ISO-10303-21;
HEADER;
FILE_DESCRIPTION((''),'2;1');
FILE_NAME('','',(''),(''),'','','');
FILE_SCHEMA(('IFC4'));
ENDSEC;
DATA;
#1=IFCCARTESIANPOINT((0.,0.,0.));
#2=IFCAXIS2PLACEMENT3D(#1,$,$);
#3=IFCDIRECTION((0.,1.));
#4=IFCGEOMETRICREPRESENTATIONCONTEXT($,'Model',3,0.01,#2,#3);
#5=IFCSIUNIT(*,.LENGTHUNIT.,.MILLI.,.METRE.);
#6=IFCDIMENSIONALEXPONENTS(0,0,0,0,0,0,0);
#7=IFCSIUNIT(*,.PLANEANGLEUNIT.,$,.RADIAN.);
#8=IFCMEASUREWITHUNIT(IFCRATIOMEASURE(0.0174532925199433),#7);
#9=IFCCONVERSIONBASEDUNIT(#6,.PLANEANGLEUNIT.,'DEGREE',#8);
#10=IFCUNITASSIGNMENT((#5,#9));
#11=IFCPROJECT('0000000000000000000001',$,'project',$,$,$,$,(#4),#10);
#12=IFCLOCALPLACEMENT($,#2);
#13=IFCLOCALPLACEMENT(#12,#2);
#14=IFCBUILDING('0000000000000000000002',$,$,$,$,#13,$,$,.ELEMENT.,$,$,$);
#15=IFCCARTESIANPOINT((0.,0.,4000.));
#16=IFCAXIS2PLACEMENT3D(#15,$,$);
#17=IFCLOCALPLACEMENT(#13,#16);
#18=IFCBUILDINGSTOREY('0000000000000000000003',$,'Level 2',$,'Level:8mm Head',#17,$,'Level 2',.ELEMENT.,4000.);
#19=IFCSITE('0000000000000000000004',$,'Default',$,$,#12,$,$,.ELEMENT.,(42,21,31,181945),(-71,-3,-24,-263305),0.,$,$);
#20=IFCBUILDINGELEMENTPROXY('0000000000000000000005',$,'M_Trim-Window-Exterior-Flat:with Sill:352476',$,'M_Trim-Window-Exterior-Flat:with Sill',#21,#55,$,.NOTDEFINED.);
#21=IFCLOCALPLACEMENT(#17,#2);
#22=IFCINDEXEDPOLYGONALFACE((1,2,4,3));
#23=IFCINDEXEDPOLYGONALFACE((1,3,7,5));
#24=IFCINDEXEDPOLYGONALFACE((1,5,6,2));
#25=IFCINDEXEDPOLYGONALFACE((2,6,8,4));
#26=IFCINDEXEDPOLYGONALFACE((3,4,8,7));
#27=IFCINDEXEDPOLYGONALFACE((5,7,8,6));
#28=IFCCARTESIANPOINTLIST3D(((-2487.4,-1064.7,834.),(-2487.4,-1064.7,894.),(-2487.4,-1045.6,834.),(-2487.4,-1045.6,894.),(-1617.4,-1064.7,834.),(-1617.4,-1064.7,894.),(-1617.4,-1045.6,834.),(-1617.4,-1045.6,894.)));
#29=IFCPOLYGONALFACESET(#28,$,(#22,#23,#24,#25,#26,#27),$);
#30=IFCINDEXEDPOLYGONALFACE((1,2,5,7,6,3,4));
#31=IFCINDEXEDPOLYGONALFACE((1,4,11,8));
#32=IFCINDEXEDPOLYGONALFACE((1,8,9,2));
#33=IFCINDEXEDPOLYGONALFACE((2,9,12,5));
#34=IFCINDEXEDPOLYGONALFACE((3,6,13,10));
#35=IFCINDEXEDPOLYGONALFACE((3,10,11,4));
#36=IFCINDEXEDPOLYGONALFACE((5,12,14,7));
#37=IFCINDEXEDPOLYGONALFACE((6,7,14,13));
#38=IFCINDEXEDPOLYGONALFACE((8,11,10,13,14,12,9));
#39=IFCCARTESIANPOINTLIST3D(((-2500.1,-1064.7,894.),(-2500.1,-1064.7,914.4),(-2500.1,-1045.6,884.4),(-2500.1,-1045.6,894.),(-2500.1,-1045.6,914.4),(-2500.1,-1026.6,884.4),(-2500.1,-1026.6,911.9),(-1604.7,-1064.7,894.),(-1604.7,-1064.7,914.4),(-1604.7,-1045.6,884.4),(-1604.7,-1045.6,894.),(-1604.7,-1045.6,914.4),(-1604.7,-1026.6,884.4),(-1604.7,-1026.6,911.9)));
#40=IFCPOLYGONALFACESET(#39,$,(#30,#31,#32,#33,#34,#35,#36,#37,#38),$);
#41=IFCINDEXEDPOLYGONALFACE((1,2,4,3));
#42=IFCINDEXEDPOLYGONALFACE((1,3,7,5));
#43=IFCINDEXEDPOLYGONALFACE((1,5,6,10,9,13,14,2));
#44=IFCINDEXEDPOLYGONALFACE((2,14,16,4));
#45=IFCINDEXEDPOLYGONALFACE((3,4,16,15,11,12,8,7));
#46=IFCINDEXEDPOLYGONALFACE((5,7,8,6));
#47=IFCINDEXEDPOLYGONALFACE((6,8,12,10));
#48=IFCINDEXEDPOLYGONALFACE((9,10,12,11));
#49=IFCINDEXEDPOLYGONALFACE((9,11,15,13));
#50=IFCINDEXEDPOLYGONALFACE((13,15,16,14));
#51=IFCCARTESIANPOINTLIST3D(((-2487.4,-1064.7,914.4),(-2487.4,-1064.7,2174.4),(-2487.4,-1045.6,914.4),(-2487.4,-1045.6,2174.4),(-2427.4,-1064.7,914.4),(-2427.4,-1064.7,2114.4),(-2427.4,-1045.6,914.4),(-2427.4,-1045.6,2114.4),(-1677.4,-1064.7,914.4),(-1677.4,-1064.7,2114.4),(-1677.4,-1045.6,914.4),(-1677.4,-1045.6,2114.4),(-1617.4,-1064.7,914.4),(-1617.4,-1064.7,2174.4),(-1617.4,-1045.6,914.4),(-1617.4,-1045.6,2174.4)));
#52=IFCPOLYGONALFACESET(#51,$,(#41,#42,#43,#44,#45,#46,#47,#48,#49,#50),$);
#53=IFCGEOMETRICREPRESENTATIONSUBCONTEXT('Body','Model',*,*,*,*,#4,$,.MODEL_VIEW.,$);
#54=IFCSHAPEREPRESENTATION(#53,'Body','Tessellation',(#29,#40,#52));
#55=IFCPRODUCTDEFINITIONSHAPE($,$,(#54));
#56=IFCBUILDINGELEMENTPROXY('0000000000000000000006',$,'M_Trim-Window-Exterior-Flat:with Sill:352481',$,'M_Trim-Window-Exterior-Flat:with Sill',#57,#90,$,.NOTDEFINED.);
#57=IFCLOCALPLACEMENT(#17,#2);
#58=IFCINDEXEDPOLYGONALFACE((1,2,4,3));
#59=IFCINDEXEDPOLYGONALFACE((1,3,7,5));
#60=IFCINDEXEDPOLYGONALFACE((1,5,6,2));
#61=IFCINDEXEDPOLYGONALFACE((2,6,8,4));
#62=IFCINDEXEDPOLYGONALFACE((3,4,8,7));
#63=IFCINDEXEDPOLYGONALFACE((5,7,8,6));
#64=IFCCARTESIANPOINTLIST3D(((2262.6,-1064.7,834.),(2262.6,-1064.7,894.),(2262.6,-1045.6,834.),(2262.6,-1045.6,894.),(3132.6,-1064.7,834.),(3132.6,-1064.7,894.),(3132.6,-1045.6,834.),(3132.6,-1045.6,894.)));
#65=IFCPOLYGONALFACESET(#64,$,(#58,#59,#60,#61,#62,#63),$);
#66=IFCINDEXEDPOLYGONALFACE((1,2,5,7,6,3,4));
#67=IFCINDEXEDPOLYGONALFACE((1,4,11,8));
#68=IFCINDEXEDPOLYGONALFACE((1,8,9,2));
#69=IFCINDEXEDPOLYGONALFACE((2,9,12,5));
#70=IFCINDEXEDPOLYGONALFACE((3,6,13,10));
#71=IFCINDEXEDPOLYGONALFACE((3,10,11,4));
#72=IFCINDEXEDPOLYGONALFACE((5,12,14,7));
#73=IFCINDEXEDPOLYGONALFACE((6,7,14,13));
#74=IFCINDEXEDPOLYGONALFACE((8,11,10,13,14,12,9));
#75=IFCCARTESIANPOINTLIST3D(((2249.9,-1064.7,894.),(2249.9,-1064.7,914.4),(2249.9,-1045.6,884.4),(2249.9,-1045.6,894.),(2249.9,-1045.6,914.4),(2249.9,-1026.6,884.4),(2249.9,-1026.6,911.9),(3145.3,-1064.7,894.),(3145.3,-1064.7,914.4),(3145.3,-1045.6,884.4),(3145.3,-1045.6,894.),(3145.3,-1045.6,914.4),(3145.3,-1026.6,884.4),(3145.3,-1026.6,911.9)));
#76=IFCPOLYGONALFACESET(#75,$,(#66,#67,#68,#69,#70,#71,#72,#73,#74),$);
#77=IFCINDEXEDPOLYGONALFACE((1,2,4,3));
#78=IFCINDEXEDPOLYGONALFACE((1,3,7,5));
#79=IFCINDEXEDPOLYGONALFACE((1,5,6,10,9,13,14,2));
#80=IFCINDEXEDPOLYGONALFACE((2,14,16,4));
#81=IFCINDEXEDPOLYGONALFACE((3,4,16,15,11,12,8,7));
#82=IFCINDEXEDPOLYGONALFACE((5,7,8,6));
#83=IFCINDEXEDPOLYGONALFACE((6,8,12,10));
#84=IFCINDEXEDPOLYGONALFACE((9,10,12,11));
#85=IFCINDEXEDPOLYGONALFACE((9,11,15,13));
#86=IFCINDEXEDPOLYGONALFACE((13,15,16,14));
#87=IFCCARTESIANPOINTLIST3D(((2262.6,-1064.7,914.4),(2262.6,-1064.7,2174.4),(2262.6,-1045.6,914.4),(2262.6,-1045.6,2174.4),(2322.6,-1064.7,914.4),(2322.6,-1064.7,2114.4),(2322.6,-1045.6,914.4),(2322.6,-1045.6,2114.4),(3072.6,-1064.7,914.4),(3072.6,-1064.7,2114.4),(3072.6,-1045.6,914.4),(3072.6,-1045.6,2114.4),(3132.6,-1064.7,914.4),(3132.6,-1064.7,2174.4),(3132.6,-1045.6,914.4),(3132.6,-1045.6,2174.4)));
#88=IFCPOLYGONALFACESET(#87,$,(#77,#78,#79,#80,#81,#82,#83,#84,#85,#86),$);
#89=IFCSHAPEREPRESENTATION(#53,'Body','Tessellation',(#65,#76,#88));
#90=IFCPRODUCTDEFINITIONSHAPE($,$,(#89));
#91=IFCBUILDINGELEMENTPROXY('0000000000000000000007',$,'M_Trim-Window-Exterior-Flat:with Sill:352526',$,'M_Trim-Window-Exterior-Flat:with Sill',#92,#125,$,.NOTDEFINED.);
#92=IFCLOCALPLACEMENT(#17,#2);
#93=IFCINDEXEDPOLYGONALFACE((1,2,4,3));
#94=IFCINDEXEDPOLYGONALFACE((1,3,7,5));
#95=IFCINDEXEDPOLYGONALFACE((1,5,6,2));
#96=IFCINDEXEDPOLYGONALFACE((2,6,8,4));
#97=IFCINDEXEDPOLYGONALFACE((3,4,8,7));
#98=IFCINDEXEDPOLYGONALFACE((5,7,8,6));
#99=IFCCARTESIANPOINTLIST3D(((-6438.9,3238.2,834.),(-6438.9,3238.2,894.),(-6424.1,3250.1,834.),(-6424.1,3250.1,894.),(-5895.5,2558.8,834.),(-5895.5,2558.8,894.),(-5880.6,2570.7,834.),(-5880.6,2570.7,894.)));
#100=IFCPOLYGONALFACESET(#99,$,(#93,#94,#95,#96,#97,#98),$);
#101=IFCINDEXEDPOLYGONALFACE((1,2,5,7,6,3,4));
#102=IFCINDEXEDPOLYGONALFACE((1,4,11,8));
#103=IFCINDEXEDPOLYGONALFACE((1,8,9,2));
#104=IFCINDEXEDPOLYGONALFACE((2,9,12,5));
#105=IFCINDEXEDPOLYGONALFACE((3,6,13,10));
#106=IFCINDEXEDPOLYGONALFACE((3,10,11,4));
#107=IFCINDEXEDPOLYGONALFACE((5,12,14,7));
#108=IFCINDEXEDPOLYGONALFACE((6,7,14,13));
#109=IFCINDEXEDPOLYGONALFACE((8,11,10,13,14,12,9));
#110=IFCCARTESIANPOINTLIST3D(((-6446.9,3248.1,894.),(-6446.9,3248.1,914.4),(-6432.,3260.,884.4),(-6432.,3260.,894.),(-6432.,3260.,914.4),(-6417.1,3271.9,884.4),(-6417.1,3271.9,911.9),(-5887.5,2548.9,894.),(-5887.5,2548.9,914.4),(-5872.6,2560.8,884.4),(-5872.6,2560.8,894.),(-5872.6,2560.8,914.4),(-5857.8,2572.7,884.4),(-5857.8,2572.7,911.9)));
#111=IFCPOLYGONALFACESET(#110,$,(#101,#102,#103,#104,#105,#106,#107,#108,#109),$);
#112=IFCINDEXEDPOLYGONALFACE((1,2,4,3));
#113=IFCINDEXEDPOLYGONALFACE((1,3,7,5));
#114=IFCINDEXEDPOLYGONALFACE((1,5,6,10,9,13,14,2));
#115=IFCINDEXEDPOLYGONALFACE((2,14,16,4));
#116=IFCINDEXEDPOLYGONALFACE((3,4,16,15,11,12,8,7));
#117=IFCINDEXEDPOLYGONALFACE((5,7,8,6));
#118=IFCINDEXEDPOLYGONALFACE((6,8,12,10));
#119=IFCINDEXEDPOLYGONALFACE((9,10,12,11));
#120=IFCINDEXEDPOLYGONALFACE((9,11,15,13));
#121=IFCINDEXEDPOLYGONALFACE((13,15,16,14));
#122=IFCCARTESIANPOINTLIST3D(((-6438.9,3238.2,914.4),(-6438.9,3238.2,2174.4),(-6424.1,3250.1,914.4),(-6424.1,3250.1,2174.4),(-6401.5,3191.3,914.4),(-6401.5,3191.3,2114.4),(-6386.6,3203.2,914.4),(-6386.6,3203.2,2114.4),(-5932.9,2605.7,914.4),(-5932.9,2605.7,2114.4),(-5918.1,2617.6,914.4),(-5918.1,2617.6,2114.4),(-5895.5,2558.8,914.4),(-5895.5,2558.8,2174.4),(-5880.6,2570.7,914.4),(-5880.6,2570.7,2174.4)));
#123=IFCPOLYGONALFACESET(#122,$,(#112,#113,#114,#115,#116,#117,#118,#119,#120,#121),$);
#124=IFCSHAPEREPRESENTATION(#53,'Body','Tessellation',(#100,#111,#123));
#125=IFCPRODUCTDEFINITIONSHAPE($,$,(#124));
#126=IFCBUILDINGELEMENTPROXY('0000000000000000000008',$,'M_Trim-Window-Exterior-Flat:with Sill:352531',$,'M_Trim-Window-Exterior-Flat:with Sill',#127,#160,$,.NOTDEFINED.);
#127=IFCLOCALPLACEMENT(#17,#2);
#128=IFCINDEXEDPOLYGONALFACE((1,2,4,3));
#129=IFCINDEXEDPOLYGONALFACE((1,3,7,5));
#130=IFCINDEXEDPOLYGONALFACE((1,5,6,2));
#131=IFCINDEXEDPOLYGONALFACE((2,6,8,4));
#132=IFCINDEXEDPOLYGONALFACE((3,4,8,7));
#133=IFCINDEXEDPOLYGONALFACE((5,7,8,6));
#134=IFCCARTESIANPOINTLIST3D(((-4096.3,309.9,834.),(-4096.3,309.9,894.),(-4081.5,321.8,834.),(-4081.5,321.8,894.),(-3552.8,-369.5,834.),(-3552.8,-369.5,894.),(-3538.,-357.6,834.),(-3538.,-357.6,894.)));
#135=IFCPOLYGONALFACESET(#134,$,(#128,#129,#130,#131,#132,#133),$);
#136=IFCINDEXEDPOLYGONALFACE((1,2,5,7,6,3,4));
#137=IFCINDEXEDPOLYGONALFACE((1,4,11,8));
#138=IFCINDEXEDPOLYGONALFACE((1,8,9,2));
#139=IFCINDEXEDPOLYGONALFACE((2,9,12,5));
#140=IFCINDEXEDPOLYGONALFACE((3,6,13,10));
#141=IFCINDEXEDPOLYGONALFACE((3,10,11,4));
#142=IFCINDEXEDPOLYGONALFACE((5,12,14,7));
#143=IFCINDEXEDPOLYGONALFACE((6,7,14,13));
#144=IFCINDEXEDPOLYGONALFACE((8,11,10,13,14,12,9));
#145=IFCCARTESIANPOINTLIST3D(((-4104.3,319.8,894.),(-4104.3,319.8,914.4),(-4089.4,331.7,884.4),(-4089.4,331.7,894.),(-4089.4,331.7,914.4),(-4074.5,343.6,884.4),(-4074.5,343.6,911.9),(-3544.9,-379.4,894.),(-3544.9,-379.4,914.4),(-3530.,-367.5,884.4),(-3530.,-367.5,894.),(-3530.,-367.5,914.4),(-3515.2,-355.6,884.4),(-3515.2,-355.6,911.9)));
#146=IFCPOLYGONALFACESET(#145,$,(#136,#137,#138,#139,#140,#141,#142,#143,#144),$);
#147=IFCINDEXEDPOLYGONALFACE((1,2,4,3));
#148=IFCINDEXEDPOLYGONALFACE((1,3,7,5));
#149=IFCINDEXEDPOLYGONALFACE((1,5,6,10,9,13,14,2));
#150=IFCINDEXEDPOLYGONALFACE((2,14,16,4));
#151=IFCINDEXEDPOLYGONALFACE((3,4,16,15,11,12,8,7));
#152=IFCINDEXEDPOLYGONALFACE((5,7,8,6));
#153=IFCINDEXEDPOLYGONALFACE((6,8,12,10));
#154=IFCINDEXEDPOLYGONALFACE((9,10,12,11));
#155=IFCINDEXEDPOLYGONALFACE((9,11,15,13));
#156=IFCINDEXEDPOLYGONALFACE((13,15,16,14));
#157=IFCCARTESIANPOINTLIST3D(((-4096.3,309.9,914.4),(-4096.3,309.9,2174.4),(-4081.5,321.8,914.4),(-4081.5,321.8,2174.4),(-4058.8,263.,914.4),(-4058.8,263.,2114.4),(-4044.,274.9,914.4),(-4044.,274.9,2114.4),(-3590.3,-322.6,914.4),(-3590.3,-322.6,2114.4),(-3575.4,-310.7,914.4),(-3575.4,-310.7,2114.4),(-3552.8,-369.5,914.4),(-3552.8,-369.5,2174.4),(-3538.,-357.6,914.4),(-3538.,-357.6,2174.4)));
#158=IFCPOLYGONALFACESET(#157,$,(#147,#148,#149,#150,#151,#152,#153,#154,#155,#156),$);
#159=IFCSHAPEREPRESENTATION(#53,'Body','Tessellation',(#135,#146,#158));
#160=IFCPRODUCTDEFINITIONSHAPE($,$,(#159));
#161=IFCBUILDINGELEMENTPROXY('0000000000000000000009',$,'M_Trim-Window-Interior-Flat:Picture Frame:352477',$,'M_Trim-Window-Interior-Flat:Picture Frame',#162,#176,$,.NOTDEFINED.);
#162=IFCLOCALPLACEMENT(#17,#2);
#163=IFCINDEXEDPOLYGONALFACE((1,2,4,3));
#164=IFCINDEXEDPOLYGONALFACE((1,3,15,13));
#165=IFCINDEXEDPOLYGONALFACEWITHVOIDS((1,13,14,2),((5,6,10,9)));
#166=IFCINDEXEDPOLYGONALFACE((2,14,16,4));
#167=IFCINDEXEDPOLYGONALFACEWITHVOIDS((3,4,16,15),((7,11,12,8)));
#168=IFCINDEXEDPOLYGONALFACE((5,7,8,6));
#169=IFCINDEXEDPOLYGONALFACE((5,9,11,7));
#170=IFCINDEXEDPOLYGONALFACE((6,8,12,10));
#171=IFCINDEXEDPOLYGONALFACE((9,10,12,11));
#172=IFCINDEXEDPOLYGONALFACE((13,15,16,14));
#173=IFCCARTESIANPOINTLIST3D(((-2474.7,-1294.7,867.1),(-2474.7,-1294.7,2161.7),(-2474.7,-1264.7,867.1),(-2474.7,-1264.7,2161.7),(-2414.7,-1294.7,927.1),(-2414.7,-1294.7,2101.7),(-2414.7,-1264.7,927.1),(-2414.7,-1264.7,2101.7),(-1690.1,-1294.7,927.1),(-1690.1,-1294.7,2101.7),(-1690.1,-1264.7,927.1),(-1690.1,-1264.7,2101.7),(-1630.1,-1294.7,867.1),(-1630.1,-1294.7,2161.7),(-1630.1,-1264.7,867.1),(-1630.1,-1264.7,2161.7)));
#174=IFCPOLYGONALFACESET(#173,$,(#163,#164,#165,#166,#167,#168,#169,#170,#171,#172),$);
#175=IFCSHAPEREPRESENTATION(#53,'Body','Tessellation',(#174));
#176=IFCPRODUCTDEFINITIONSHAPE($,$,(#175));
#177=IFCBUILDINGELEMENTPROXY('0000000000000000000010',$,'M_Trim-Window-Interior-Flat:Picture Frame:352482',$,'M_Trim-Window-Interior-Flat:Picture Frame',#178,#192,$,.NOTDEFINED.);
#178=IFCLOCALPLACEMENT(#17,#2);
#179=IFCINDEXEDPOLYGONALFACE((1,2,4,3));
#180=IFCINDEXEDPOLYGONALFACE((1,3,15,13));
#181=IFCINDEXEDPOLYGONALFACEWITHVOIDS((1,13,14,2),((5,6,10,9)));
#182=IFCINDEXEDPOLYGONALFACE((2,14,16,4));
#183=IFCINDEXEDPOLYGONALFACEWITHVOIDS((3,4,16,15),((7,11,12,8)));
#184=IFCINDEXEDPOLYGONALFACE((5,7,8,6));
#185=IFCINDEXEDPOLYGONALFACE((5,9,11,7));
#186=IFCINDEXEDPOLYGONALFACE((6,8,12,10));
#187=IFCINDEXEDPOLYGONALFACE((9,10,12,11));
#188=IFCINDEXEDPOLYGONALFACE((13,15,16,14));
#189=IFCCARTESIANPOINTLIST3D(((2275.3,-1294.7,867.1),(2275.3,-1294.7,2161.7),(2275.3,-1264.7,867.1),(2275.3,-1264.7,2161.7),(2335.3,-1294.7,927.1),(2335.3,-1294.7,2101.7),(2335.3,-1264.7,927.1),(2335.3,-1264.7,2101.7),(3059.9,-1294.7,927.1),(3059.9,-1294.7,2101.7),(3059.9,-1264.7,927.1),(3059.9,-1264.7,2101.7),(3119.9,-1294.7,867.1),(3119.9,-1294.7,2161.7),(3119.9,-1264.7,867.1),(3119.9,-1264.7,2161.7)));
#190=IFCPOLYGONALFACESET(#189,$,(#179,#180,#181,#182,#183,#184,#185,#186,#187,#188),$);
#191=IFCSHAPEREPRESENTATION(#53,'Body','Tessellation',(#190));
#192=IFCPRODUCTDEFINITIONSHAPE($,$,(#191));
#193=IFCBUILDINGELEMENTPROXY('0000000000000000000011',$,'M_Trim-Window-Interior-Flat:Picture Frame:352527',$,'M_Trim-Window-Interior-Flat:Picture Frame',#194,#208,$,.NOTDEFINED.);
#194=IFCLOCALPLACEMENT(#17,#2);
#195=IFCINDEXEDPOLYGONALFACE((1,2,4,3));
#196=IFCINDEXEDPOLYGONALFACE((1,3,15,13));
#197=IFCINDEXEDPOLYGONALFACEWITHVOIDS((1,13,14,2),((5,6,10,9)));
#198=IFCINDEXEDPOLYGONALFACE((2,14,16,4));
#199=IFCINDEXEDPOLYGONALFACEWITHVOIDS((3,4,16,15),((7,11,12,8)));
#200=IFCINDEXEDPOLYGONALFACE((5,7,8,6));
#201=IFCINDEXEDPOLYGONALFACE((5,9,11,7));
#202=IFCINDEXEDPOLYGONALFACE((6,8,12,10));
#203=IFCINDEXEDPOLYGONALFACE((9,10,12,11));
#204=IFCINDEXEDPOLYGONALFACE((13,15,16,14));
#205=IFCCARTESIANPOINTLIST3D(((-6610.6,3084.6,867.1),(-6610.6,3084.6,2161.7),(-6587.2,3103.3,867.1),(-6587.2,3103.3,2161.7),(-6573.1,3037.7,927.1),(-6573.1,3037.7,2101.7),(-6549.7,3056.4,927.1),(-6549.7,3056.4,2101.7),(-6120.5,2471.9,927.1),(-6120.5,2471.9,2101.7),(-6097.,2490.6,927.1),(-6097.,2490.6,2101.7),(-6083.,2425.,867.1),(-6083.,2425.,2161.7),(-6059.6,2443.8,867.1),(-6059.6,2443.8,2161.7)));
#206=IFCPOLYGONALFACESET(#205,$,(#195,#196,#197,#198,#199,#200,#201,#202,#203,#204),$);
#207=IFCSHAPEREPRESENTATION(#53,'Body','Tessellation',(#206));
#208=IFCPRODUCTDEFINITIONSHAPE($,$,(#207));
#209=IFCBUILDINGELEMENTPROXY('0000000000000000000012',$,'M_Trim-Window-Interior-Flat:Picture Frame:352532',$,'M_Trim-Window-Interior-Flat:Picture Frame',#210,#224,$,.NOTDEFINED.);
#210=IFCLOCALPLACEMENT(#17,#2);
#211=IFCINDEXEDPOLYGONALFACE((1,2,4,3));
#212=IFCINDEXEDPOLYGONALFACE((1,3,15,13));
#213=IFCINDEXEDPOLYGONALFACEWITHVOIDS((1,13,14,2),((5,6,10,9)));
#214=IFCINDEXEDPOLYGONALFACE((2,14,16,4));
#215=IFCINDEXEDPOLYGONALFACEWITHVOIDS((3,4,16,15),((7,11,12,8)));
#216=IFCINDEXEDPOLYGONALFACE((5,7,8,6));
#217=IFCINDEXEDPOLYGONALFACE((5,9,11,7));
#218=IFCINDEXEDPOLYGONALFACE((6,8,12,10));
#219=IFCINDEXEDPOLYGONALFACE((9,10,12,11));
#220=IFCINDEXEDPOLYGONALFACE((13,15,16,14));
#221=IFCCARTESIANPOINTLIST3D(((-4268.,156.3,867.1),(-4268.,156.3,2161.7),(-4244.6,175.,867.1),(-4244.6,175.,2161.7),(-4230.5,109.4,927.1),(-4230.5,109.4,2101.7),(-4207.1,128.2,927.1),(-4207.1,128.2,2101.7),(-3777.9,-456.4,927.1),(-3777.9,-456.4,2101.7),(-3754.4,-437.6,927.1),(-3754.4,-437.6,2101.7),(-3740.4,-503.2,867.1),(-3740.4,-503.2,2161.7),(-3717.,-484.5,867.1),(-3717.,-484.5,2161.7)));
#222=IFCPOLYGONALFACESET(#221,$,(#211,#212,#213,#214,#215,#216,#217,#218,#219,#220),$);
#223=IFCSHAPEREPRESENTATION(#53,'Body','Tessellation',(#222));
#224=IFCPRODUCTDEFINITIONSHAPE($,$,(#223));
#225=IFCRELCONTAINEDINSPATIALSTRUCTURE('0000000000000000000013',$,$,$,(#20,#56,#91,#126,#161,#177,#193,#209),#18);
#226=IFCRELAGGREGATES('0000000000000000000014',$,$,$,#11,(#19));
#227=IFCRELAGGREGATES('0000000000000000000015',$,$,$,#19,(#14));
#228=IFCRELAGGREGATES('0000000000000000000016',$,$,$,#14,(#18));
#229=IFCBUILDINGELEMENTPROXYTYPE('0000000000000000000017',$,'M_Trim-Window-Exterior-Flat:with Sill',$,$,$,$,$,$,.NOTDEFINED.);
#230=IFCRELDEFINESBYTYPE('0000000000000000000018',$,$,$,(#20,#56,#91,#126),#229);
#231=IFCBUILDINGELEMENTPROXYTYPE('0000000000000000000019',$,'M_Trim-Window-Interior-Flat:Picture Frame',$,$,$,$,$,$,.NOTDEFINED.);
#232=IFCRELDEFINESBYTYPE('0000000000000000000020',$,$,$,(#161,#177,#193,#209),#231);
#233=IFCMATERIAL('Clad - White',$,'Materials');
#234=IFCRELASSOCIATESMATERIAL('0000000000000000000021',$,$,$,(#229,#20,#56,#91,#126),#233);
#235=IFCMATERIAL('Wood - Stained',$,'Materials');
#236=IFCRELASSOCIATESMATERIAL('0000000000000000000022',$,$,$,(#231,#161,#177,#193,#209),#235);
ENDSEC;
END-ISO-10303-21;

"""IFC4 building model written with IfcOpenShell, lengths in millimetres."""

from ifc_helpers import new_model, entity, si_unit, converted_unit, direction, frame, frame_2d, origin, place, context, subcontext, project, spatial, polyline, rectangle, outline, extrude, source, transform, mapped, material, type_object, type_shapes, element, save


model = new_model("IFC4")

# Units and contexts
model_context = context("Model", 3, precision=0.01, world=origin(), true_north=direction((0.0, 1.0)))
body_context = subcontext(model_context, "Body", "Model", "MODEL_VIEW")
ifc_project = project(units=[si_unit("LENGTHUNIT", "METRE", prefix="MILLI"), converted_unit("PLANEANGLEUNIT", "DEGREE", entity("IfcRatioMeasure", 0.0174532925199433), si_unit("PLANEANGLEUNIT", "RADIAN"), dimensions=[0, 0, 0, 0, 0, 0, 0])], contexts=[model_context])

# Site, building, storey
site_placement = place(None, origin())
site = spatial("IfcSite", under=ifc_project, at=site_placement, Name="Default", CompositionType="ELEMENT", RefLatitude=(42, 21, 31, 181945), RefLongitude=(-71, -3, -24, -263305), RefElevation=0.0)
building_placement = place(site_placement, origin())
building = spatial("IfcBuilding", under=site, at=building_placement, CompositionType="ELEMENT")
storey_placement = place(building_placement, frame((0.0, 0.0, 4000.0)))
storey = spatial("IfcBuildingStorey", under=building, at=storey_placement, Name="Level 2", ObjectType="Level:8mm Head", LongName="Level 2", CompositionType="ELEMENT", Elevation=4000.0)

# Shared definitions
ifc_material_1 = material(Name="Wood - Stained", Category="Materials")

# Building element proxies
ifc_material_2 = material(Name="Clad - White", Category="Materials")
building_element_proxy_type_1 = type_object("IfcBuildingElementProxyType", Name="M_Trim-Window-Exterior-Flat:with Sill", PredefinedType="NOTDEFINED", material=ifc_material_2)
shared_shape_1 = source(origin(), body_context, "Body", "SweptSolid", [
    extrude(rectangle(XDim=870.0, YDim=60.0, at=frame_2d((0.0, 0.0), x_axis=(1.0, 0.0))), frame((0.0, -1250.4, 0.0), z_axis=(0.0, 0.0, 1.0), x_axis=(-1.0, 0.0, 0.0)), (0.0, 0.0, 1.0), 19.1),
    extrude(outline(polyline([(-19.0, -15.2), (0.0, -15.2), (0.0, -5.7), (19.0, -5.7), (19.0, 14.8), (0.0, 14.8), (-19.0, 12.3), (-19.0, -15.2)])), frame((-447.7, -1214.8, 19.0), z_axis=(1.0, 0.0, 0.0), x_axis=(0.0, 0.0, -1.0)), (0.0, 0.0, 1.0), 895.4),
    extrude(outline(polyline([(-645.0, -435.0), (615.0, -435.0), (615.0, -375.0), (-585.0, -375.0), (-585.0, 375.0), (615.0, 375.0), (615.0, 435.0), (-645.0, 435.0), (-645.0, -435.0)])), frame((0.0, -585.0, 0.0), z_axis=(0.0, 0.0, 1.0), x_axis=(0.0, -1.0, 0.0)), (0.0, 0.0, 1.0), 19.1),
])
type_shapes(building_element_proxy_type_1, [shared_shape_1])
for number, where, z_axis, x_axis, name in (
    (1, (-2052.4, -1064.7, 2114.4), (0.0, 1.0, 0.0), (-1.0, 0.0, 0.0), "M_Trim-Window-Exterior-Flat:with Sill:352476"),
    (2, (2697.6, -1064.7, 2114.4), (0.0, 1.0, 0.0), (-1.0, 0.0, 0.0), "M_Trim-Window-Exterior-Flat:with Sill:352481"),
    (3, (-6167.2, 2898.5, 2114.4), (0.780869, 0.624695, 0.0), (-0.624695, 0.780869, 0.0), "M_Trim-Window-Exterior-Flat:with Sill:352526"),
    (4, (-3824.6, -29.8, 2114.4), (0.780869, 0.624695, 0.0), (-0.624695, 0.780869, 0.0), "M_Trim-Window-Exterior-Flat:with Sill:352531"),
):
    element("IfcBuildingElementProxy", number, at=place(storey_placement, frame(where, z_axis=z_axis, x_axis=x_axis)), inside=storey, type_object=building_element_proxy_type_1, material=ifc_material_2, Name=name, ObjectType="M_Trim-Window-Exterior-Flat:with Sill", PredefinedType="NOTDEFINED", context=body_context, shape_type="MappedRepresentation", body=[
        mapped(shared_shape_1, transform((0.0, 0.0, 0.0), scale=1.0)),
    ])
building_element_proxy_type_2 = type_object("IfcBuildingElementProxyType", Name="M_Trim-Window-Interior-Flat:Picture Frame", PredefinedType="NOTDEFINED", material=ifc_material_1)
shared_shape_2 = source(origin(), body_context, "Body", "SweptSolid", [
    extrude(outline(polyline([(-422.3, -647.3), (422.3, -647.3), (422.3, 647.3), (-422.3, 647.3), (-422.3, -647.3)]), holes=[polyline([(-362.3, -587.3), (-362.3, 587.3), (362.3, 587.3), (362.3, -587.3), (-362.3, -587.3)])]), frame((0.0, -600.0, 0.0), z_axis=(0.0, 0.0, 1.0), x_axis=(-1.0, 0.0, 0.0)), (0.0, 0.0, 1.0), 30.0),
])
type_shapes(building_element_proxy_type_2, [shared_shape_2])
for number, where, z_axis, x_axis, name in (
    (5, (-2052.4, -1264.7, 2114.4), (0.0, -1.0, 0.0), (1.0, 0.0, 0.0), "M_Trim-Window-Interior-Flat:Picture Frame:352477"),
    (6, (2697.6, -1264.7, 2114.4), (0.0, -1.0, 0.0), (1.0, 0.0, 0.0), "M_Trim-Window-Interior-Flat:Picture Frame:352482"),
    (7, (-6323.4, 2773.5, 2114.4), (-0.780869, -0.624695, 0.0), (0.624695, -0.780869, 0.0), "M_Trim-Window-Interior-Flat:Picture Frame:352527"),
    (8, (-3980.8, -154.7, 2114.4), (-0.780869, -0.624695, 0.0), (0.624695, -0.780869, 0.0), "M_Trim-Window-Interior-Flat:Picture Frame:352532"),
):
    element("IfcBuildingElementProxy", number, at=place(storey_placement, frame(where, z_axis=z_axis, x_axis=x_axis)), inside=storey, type_object=building_element_proxy_type_2, material=ifc_material_1, Name=name, ObjectType="M_Trim-Window-Interior-Flat:Picture Frame", PredefinedType="NOTDEFINED", context=body_context, shape_type="MappedRepresentation", body=[
        mapped(shared_shape_2, transform((0.0, 0.0, 0.0), scale=1.0)),
    ])

save(model, "model.ifc")
